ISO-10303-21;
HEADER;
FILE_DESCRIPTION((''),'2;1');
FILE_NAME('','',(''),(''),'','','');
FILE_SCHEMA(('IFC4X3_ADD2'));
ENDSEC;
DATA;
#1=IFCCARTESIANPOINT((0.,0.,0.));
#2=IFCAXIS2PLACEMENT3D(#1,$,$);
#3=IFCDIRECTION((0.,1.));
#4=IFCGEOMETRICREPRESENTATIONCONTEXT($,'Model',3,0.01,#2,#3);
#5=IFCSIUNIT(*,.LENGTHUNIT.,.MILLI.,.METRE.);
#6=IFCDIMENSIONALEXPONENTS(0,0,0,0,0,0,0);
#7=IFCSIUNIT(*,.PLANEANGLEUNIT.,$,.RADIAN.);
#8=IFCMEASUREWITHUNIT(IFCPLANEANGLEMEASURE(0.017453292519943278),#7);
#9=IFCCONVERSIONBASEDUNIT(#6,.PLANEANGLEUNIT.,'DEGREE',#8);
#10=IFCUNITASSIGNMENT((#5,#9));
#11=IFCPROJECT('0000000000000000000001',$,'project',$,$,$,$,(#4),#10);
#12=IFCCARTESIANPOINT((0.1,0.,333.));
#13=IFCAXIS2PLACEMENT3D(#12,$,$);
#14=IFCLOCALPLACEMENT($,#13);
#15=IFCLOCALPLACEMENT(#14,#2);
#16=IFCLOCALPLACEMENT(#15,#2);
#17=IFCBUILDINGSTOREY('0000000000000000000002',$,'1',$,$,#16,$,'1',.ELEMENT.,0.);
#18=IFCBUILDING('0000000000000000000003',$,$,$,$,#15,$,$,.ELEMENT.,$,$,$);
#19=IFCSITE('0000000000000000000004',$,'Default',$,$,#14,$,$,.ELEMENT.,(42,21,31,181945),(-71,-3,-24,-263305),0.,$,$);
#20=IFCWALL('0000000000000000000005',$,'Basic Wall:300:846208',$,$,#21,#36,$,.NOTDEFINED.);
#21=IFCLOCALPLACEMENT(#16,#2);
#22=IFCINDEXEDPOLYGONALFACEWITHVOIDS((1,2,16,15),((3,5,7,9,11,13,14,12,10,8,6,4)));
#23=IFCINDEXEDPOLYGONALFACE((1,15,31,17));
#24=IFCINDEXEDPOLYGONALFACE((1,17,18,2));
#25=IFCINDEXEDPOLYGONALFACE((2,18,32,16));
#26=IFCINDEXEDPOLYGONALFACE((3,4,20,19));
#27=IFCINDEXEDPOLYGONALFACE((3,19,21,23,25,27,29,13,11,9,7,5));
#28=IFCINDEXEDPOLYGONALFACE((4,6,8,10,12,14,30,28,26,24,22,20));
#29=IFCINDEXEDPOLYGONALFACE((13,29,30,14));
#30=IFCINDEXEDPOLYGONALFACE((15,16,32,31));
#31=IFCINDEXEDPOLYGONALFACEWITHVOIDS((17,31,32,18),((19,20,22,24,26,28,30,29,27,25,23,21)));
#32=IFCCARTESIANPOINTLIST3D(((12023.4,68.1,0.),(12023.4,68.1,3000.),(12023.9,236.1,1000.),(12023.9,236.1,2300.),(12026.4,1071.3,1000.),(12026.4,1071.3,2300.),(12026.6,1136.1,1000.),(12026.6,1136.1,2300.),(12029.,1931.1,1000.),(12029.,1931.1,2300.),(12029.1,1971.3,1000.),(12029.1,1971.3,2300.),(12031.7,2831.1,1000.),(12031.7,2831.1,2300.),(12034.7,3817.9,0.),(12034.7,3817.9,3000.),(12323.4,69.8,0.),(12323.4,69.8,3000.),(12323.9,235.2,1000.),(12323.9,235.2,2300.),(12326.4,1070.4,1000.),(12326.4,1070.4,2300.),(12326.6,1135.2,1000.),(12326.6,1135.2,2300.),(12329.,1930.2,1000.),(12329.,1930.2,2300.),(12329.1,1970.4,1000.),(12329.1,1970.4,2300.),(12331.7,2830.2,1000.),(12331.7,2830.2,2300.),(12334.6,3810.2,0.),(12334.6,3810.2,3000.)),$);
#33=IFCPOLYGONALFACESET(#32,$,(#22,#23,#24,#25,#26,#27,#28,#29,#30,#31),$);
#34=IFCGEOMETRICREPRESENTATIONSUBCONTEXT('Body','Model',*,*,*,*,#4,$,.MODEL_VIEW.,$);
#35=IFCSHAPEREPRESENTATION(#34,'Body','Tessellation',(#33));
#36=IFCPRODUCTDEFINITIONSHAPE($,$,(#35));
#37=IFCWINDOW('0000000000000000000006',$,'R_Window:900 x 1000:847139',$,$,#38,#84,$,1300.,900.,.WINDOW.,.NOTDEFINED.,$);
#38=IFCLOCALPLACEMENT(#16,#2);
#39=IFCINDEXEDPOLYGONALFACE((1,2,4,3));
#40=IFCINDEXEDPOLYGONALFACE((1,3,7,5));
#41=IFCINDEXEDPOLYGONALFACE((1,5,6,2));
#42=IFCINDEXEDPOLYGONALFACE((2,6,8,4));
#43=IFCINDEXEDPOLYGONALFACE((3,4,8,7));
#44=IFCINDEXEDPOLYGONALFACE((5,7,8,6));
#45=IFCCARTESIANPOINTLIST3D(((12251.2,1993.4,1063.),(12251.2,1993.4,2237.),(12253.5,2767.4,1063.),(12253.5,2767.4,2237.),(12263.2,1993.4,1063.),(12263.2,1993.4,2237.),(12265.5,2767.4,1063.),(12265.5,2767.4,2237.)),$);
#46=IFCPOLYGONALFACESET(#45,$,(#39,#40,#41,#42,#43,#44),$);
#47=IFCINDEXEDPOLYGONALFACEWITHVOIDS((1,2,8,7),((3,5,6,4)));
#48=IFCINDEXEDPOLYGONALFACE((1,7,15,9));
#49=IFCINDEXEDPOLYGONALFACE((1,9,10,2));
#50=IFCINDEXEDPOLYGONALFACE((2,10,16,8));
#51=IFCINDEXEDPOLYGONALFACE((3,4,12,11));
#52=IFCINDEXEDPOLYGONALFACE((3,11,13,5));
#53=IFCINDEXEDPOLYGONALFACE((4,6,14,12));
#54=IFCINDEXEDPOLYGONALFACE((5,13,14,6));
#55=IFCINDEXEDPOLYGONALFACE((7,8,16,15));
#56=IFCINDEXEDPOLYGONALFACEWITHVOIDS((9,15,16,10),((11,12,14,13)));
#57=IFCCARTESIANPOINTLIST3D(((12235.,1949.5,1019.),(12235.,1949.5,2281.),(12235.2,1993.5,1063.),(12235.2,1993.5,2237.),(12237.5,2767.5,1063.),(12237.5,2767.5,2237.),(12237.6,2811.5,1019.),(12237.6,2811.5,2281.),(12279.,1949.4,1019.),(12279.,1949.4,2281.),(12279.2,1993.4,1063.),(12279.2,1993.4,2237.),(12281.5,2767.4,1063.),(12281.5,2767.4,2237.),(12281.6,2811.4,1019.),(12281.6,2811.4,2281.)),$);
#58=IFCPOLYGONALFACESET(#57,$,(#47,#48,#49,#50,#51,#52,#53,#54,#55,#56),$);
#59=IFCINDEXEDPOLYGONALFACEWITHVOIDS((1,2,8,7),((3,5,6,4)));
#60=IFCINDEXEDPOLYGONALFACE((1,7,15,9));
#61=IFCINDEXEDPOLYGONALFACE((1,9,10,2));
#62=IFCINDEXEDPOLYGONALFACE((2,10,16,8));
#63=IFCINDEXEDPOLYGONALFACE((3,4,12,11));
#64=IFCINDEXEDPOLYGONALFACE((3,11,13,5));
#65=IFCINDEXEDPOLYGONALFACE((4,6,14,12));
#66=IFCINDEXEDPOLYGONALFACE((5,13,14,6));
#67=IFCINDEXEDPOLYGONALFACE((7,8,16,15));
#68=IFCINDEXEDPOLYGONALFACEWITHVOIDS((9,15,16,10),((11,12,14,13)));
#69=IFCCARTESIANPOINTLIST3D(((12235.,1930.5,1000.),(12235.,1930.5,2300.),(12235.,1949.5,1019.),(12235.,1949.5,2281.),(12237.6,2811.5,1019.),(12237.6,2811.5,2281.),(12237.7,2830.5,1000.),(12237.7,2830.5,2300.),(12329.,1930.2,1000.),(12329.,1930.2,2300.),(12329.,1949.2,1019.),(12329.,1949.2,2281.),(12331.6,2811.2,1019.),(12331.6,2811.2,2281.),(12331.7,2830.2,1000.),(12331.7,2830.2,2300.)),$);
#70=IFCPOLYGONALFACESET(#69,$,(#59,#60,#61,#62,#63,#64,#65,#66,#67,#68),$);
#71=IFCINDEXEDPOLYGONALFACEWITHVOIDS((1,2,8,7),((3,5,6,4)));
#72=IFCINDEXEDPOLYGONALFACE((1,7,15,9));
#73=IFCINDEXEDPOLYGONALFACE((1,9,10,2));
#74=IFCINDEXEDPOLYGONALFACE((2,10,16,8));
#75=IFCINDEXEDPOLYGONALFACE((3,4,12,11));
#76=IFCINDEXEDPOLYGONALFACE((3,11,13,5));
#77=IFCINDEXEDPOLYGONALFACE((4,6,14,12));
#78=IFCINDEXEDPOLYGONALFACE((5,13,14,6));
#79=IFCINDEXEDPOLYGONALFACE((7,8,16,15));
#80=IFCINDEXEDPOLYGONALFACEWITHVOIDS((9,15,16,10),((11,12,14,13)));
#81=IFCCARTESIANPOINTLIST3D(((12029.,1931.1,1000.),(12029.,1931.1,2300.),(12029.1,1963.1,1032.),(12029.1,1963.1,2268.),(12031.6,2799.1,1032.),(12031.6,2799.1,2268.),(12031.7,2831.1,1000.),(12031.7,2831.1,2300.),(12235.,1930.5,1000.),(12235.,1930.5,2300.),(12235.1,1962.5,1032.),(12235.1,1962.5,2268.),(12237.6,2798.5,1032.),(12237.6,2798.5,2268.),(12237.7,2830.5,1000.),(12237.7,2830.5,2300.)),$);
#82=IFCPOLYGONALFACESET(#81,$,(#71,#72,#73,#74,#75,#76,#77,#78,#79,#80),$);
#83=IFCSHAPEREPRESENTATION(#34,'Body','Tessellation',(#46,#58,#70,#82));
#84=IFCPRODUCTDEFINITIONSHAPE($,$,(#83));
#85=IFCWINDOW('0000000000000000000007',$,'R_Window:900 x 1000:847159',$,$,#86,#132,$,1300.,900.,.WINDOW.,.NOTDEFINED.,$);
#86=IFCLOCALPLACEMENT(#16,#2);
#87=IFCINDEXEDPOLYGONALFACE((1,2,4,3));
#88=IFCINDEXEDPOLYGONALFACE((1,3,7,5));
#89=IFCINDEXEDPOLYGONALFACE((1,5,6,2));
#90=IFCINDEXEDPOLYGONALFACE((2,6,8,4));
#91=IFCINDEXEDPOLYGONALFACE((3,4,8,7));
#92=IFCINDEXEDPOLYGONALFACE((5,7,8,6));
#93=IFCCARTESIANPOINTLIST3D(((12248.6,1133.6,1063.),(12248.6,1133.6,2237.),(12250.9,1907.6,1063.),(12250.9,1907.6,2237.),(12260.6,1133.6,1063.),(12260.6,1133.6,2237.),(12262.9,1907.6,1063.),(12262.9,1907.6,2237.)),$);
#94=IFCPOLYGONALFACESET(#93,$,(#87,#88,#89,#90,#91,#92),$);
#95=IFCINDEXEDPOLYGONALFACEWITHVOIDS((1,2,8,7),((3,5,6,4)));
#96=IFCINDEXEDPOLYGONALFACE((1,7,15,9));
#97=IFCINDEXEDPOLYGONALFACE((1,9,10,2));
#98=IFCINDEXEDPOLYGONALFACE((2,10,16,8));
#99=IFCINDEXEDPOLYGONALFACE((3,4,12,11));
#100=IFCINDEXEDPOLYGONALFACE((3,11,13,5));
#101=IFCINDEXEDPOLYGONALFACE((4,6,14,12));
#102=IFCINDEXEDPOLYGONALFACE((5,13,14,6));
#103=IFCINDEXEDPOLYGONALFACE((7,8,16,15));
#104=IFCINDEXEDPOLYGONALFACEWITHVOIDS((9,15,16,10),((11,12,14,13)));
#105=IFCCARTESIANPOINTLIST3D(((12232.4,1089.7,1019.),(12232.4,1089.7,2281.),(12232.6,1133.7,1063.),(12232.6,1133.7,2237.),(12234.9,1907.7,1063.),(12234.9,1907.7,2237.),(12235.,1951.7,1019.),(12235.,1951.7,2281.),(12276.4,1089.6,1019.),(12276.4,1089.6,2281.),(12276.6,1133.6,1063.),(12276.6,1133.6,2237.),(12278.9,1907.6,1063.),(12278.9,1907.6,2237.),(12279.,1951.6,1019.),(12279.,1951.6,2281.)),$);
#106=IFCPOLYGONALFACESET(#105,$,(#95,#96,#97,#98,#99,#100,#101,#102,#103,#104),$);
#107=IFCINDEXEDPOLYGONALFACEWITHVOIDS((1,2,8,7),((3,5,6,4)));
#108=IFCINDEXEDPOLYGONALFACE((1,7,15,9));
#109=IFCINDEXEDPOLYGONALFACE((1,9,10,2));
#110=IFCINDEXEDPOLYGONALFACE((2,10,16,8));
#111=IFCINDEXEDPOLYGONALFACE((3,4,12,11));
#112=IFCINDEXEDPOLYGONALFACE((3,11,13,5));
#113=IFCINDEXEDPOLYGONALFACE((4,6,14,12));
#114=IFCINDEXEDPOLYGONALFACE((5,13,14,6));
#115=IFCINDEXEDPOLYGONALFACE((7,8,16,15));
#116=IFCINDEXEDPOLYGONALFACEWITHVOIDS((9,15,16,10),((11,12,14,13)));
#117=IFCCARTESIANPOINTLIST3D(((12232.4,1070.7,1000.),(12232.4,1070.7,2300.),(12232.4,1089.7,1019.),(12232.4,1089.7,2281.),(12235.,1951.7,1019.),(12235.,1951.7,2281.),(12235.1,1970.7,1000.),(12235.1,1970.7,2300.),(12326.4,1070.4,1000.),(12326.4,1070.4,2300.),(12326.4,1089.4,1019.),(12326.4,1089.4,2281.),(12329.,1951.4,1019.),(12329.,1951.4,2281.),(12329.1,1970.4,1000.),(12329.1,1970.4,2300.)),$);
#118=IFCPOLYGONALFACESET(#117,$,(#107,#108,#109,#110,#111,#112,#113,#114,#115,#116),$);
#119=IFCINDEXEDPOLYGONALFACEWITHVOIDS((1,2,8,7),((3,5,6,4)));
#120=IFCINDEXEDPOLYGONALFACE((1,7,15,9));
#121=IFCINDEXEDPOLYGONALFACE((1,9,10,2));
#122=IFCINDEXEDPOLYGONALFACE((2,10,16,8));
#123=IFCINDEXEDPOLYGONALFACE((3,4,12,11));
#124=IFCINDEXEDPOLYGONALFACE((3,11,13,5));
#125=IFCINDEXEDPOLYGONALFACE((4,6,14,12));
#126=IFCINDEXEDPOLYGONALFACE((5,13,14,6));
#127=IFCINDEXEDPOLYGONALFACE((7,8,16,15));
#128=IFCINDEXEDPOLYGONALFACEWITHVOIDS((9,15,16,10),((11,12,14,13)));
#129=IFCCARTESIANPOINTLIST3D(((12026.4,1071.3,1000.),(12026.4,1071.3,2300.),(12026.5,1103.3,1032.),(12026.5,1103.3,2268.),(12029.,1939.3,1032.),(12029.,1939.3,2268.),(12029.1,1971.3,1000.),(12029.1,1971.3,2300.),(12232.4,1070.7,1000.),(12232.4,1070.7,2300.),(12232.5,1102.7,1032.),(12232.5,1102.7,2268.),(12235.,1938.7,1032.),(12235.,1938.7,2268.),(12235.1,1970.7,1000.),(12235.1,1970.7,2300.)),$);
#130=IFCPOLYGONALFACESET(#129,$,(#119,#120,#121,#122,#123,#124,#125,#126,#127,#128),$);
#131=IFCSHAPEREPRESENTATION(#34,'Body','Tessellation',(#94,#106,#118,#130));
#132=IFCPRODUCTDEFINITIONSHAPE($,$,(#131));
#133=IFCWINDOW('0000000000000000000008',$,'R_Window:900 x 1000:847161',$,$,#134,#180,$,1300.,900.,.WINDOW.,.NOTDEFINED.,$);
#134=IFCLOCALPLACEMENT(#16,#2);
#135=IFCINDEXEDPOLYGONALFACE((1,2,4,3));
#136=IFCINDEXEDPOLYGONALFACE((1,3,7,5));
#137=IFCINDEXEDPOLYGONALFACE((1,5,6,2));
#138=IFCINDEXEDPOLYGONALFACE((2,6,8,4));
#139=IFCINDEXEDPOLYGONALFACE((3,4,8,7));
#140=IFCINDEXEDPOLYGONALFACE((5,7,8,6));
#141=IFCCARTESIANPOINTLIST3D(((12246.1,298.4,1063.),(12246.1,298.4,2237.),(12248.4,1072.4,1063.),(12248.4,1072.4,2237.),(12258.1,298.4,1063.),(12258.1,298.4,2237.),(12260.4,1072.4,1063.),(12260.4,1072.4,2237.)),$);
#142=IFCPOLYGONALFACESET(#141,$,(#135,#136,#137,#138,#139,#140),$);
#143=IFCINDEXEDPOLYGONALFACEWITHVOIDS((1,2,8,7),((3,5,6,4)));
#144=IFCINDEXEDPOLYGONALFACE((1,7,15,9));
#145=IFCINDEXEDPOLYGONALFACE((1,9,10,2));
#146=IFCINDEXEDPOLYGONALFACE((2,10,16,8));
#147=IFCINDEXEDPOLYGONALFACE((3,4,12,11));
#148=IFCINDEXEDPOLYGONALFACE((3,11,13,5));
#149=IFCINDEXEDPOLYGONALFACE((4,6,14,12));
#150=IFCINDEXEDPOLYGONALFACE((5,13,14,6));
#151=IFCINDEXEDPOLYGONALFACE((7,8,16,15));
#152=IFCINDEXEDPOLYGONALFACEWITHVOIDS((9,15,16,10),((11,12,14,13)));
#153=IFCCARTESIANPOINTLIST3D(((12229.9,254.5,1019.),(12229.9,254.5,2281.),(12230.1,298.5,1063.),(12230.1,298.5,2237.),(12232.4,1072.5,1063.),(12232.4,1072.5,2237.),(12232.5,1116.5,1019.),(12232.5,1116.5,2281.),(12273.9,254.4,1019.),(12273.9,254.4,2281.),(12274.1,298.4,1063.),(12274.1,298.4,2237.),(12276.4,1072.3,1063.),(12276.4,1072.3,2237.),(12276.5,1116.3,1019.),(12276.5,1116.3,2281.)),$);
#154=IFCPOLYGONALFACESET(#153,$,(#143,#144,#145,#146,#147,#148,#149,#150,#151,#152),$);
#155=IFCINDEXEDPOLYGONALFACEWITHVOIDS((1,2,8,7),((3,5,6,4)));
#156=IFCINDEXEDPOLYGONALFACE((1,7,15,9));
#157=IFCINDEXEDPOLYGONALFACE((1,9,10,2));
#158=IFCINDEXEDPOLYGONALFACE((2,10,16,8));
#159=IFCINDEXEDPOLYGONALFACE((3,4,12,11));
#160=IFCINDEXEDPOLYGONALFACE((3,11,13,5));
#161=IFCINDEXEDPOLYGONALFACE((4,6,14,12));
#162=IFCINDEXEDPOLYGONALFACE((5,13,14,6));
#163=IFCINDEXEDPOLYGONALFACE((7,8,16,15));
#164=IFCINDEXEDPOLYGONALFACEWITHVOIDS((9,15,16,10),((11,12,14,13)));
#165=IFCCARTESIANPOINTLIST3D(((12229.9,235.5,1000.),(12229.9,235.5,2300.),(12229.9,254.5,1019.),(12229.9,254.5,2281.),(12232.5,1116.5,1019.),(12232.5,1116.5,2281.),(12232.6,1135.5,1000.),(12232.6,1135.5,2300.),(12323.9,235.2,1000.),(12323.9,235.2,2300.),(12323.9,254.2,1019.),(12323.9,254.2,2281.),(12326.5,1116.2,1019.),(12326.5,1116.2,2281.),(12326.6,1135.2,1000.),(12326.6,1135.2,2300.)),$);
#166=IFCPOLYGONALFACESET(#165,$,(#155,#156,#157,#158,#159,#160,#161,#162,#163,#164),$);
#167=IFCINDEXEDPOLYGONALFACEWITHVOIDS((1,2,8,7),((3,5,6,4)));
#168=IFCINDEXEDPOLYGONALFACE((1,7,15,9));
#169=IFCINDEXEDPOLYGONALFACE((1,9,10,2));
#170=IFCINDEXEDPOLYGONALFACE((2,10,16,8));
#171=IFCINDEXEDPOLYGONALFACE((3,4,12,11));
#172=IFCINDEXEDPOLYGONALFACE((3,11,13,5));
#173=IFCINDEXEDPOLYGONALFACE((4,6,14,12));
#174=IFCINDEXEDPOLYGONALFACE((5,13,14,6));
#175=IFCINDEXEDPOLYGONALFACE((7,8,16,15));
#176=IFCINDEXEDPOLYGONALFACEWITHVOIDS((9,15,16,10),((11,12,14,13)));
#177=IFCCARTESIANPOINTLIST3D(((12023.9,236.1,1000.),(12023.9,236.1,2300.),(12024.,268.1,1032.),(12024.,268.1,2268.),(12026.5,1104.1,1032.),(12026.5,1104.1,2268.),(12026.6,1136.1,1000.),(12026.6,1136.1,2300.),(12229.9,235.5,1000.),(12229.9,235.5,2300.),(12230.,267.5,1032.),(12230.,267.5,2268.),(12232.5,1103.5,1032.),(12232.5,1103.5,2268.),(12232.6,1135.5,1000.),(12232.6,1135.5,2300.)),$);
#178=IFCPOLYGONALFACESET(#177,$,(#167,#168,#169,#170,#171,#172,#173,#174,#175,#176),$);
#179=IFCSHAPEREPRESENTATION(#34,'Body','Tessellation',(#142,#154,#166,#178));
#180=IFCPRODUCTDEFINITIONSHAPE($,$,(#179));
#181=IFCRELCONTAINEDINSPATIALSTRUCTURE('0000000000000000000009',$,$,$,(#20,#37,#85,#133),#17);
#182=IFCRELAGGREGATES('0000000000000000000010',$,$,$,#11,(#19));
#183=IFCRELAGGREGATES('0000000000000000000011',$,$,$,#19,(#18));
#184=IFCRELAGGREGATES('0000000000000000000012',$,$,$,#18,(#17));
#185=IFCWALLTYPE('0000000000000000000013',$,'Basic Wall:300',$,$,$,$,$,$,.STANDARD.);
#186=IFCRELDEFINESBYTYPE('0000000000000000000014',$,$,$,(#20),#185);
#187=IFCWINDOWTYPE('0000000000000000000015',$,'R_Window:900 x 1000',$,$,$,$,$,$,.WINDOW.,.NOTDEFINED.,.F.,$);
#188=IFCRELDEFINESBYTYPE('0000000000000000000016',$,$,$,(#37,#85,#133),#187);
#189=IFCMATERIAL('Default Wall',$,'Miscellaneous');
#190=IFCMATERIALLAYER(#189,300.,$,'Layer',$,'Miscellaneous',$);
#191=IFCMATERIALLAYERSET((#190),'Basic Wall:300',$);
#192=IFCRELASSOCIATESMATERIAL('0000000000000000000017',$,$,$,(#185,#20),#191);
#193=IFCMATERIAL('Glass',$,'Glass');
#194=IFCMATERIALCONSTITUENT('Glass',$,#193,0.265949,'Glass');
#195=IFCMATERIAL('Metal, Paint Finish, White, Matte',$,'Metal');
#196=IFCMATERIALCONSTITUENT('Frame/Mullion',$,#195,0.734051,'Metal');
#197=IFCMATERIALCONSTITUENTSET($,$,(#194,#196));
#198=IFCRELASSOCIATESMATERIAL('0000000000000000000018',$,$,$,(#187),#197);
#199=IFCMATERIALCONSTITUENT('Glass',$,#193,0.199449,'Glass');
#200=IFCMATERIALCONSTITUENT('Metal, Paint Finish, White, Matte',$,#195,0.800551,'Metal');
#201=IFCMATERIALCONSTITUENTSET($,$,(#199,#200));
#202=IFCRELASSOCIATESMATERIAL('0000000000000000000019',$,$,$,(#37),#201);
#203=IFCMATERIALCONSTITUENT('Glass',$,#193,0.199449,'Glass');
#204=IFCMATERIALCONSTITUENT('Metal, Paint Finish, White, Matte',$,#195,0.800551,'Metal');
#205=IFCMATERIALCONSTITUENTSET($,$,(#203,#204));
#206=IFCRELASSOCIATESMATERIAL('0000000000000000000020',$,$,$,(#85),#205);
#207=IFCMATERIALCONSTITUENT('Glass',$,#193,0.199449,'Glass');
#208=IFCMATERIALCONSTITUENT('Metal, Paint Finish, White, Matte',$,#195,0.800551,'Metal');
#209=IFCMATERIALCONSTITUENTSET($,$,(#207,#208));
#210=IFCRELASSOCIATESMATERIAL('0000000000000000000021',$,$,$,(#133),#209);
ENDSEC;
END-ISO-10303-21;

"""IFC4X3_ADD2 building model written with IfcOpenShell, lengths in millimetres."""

from ifc_helpers import new_model, entity, si_unit, converted_unit, direction, frame, frame_2d, origin, place, context, subcontext, project, spatial, polyline, rectangle, outline, extrude, source, transform, mapped, material, layer, layer_set, constituent, constituent_set, type_object, type_shapes, element, fill, save


model = new_model("IFC4X3_ADD2")

# Units and contexts
model_context = context("Model", 3, precision=0.01, world=origin(), true_north=direction((0.0, 1.0)))
body_context = subcontext(model_context, "Body", "Model", "MODEL_VIEW")
ifc_project = project(units=[si_unit("LENGTHUNIT", "METRE", prefix="MILLI"), converted_unit("PLANEANGLEUNIT", "DEGREE", entity("IfcPlaneAngleMeasure", 0.017453292519943278), si_unit("PLANEANGLEUNIT", "RADIAN"), dimensions=[0, 0, 0, 0, 0, 0, 0])], contexts=[model_context])

# Site, building, storey
site_placement = place(None, frame((0.1, 0.0, 333.0)))
site = spatial("IfcSite", under=ifc_project, at=site_placement, Name="Default", CompositionType="ELEMENT", RefLatitude=(42, 21, 31, 181945), RefLongitude=(-71, -3, -24, -263305), RefElevation=0.0)
building_placement = place(site_placement, origin())
building = spatial("IfcBuilding", under=site, at=building_placement, CompositionType="ELEMENT")
storey_placement = place(building_placement, origin())
storey = spatial("IfcBuildingStorey", under=building, at=storey_placement, Name="1", LongName="1", CompositionType="ELEMENT", Elevation=0.0)

# Shared definitions
ifc_material_1 = material(Name="Default Wall", Category="Miscellaneous")
ifc_layer_1 = layer(ifc_material_1, 300.0, Name="Layer", Category="Miscellaneous")
ifc_layer_set_1 = layer_set([ifc_layer_1], Name="Basic Wall:300")
wall_type_1 = type_object("IfcWallType", Name="Basic Wall:300", PredefinedType="STANDARD", material=ifc_layer_set_1)

# Wall, openings, windows
wall_1_placement = place(storey_placement, frame((12184.7, 3817.4, 0.0), z_axis=(0.0, 0.0, 1.0), x_axis=(-0.003012, -0.999995, 0.0)))
wall_1 = element("IfcWall", 1, at=wall_1_placement, inside=storey, type_object=wall_type_1, material=ifc_layer_set_1, Name="Basic Wall:300:846208", PredefinedType="NOTDEFINED", context=body_context, shape_type="SweptSolid", body=[
    extrude(outline(polyline([(3749.8, -150.0), (3747.2, 150.0), (6.8, 150.0), (0.0, -150.0), (300.1, -150.0), (3749.8, -150.0)])), origin(), (0.0, 0.0, 1.0), 3000.0),
])
opening_1_placement = place(wall_1_placement, frame((986.8, -150.0, 1000.0)))
opening_1 = element("IfcOpeningElement", 2, at=opening_1_placement, cuts=wall_1, PredefinedType="OPENING", context=body_context, shape_type="SweptSolid", body=[
    extrude(rectangle(XDim=1300.0, YDim=900.0, at=frame_2d((650.0, 450.0), x_axis=(1.0, 0.0))), frame((0.0, 0.0, 0.0), z_axis=(0.0, 1.0, 0.0), x_axis=(0.0, 0.0, 1.0)), (0.0, 0.0, 1.0), 300.0),
])
opening_2_placement = place(wall_1_placement, frame((1846.6, -150.0, 1000.0)))
opening_2 = element("IfcOpeningElement", 3, at=opening_2_placement, cuts=wall_1, PredefinedType="OPENING", context=body_context, shape_type="SweptSolid", body=[
    extrude(rectangle(XDim=1300.0, YDim=900.0, at=frame_2d((650.0, 450.0), x_axis=(1.0, 0.0))), frame((0.0, 0.0, 0.0), z_axis=(0.0, 1.0, 0.0), x_axis=(0.0, 0.0, 1.0)), (0.0, 0.0, 1.0), 300.0),
])
opening_3_placement = place(wall_1_placement, frame((2681.8, -150.0, 1000.0)))
opening_3 = element("IfcOpeningElement", 4, at=opening_3_placement, cuts=wall_1, PredefinedType="OPENING", context=body_context, shape_type="SweptSolid", body=[
    extrude(rectangle(XDim=1300.0, YDim=900.0, at=frame_2d((650.0, 450.0), x_axis=(1.0, 0.0))), frame((0.0, 0.0, 0.0), z_axis=(0.0, 1.0, 0.0), x_axis=(0.0, 0.0, 1.0)), (0.0, 0.0, 1.0), 300.0),
])
ifc_material_2 = material(Name="Glass", Category="Glass")
ifc_constituent_1 = constituent(ifc_material_2, Name="Glass", Category="Glass", fraction=0.199449)
ifc_material_3 = material(Name="Metal, Paint Finish, White, Matte", Category="Metal")
ifc_constituent_2 = constituent(ifc_material_3, Name="Metal, Paint Finish, White, Matte", Category="Metal", fraction=0.800551)
ifc_constituent_set_1 = constituent_set(constituents=[ifc_constituent_1, ifc_constituent_2])
ifc_constituent_3 = constituent(ifc_material_2, Name="Glass", Category="Glass", fraction=0.265949)
ifc_constituent_4 = constituent(ifc_material_3, Name="Frame/Mullion", Category="Metal", fraction=0.734051)
ifc_constituent_set_2 = constituent_set(constituents=[ifc_constituent_3, ifc_constituent_4])
window_type = type_object("IfcWindowType", Name="R_Window:900 x 1000", ParameterTakesPrecedence=False, PartitioningType="NOTDEFINED", PredefinedType="WINDOW", material=ifc_constituent_set_2)
shared_shape_1 = source(origin(), body_context, "Body", "SweptSolid", [
    extrude(rectangle(XDim=12.0, YDim=774.0, at=frame_2d((0.0, 0.0), x_axis=(1.0, 0.0))), frame((450.0, 228.0, 63.0), z_axis=(0.0, 0.0, 1.0), x_axis=(0.0, -1.0, 0.0)), (0.0, 0.0, 1.0), 1174.0),
    extrude(outline(polyline([(-431.0, -631.0), (431.0, -631.0), (431.0, 631.0), (-431.0, 631.0), (-431.0, -631.0)]), holes=[polyline([(-387.0, -587.0), (-387.0, 587.0), (387.0, 587.0), (387.0, -587.0), (-387.0, -587.0)])]), frame((450.0, 206.0, 650.0), z_axis=(0.0, 1.0, 0.0), x_axis=(1.0, 0.0, 0.0)), (0.0, 0.0, 1.0), 44.0),
    extrude(outline(polyline([(-450.0, -650.0), (450.0, -650.0), (450.0, 650.0), (-450.0, 650.0), (-450.0, -650.0)]), holes=[polyline([(-431.0, -631.0), (-431.0, 631.0), (431.0, 631.0), (431.0, -631.0), (-431.0, -631.0)])]), frame((450.0, 206.0, 650.0), z_axis=(0.0, 1.0, 0.0), x_axis=(1.0, 0.0, 0.0)), (0.0, 0.0, 1.0), 94.0),
    extrude(outline(polyline([(-450.0, -650.0), (450.0, -650.0), (450.0, 650.0), (-450.0, 650.0), (-450.0, -650.0)]), holes=[polyline([(-418.0, -618.0), (-418.0, 618.0), (418.0, 618.0), (418.0, -618.0), (-418.0, -618.0)])]), frame((450.0, 0.0, 650.0), z_axis=(0.0, 1.0, 0.0), x_axis=(1.0, 0.0, 0.0)), (0.0, 0.0, 1.0), 206.0),
])
type_shapes(window_type, [shared_shape_1])
window_1_placement = place(opening_1_placement, origin())
window_1 = element("IfcWindow", 5, at=window_1_placement, inside=storey, type_object=window_type, material=ifc_constituent_set_1, Name="R_Window:900 x 1000:847139", OverallHeight=1300.0, OverallWidth=900.0, PartitioningType="NOTDEFINED", PredefinedType="WINDOW", context=body_context, shape_type="MappedRepresentation", body=[
    mapped(shared_shape_1, transform((0.0, 0.0, 0.0), scale=1.0)),
])
fill(opening_1, window_1)
ifc_constituent_5 = constituent(ifc_material_2, Name="Glass", Category="Glass", fraction=0.199449)
ifc_constituent_6 = constituent(ifc_material_3, Name="Metal, Paint Finish, White, Matte", Category="Metal", fraction=0.800551)
ifc_constituent_set_3 = constituent_set(constituents=[ifc_constituent_5, ifc_constituent_6])
window_2_placement = place(opening_2_placement, origin())
window_2 = element("IfcWindow", 6, at=window_2_placement, inside=storey, type_object=window_type, material=ifc_constituent_set_3, Name="R_Window:900 x 1000:847159", OverallHeight=1300.0, OverallWidth=900.0, PartitioningType="NOTDEFINED", PredefinedType="WINDOW", context=body_context, shape_type="MappedRepresentation", body=[
    mapped(shared_shape_1, transform((0.0, 0.0, 0.0), scale=1.0)),
])
fill(opening_2, window_2)
ifc_constituent_7 = constituent(ifc_material_2, Name="Glass", Category="Glass", fraction=0.199449)
ifc_constituent_8 = constituent(ifc_material_3, Name="Metal, Paint Finish, White, Matte", Category="Metal", fraction=0.800551)
ifc_constituent_set_4 = constituent_set(constituents=[ifc_constituent_7, ifc_constituent_8])
window_3_placement = place(opening_3_placement, origin())
window_3 = element("IfcWindow", 7, at=window_3_placement, inside=storey, type_object=window_type, material=ifc_constituent_set_4, Name="R_Window:900 x 1000:847161", OverallHeight=1300.0, OverallWidth=900.0, PartitioningType="NOTDEFINED", PredefinedType="WINDOW", context=body_context, shape_type="MappedRepresentation", body=[
    mapped(shared_shape_1, transform((0.0, 0.0, 0.0), scale=1.0)),
])
fill(opening_3, window_3)

save(model, "model.ifc")
